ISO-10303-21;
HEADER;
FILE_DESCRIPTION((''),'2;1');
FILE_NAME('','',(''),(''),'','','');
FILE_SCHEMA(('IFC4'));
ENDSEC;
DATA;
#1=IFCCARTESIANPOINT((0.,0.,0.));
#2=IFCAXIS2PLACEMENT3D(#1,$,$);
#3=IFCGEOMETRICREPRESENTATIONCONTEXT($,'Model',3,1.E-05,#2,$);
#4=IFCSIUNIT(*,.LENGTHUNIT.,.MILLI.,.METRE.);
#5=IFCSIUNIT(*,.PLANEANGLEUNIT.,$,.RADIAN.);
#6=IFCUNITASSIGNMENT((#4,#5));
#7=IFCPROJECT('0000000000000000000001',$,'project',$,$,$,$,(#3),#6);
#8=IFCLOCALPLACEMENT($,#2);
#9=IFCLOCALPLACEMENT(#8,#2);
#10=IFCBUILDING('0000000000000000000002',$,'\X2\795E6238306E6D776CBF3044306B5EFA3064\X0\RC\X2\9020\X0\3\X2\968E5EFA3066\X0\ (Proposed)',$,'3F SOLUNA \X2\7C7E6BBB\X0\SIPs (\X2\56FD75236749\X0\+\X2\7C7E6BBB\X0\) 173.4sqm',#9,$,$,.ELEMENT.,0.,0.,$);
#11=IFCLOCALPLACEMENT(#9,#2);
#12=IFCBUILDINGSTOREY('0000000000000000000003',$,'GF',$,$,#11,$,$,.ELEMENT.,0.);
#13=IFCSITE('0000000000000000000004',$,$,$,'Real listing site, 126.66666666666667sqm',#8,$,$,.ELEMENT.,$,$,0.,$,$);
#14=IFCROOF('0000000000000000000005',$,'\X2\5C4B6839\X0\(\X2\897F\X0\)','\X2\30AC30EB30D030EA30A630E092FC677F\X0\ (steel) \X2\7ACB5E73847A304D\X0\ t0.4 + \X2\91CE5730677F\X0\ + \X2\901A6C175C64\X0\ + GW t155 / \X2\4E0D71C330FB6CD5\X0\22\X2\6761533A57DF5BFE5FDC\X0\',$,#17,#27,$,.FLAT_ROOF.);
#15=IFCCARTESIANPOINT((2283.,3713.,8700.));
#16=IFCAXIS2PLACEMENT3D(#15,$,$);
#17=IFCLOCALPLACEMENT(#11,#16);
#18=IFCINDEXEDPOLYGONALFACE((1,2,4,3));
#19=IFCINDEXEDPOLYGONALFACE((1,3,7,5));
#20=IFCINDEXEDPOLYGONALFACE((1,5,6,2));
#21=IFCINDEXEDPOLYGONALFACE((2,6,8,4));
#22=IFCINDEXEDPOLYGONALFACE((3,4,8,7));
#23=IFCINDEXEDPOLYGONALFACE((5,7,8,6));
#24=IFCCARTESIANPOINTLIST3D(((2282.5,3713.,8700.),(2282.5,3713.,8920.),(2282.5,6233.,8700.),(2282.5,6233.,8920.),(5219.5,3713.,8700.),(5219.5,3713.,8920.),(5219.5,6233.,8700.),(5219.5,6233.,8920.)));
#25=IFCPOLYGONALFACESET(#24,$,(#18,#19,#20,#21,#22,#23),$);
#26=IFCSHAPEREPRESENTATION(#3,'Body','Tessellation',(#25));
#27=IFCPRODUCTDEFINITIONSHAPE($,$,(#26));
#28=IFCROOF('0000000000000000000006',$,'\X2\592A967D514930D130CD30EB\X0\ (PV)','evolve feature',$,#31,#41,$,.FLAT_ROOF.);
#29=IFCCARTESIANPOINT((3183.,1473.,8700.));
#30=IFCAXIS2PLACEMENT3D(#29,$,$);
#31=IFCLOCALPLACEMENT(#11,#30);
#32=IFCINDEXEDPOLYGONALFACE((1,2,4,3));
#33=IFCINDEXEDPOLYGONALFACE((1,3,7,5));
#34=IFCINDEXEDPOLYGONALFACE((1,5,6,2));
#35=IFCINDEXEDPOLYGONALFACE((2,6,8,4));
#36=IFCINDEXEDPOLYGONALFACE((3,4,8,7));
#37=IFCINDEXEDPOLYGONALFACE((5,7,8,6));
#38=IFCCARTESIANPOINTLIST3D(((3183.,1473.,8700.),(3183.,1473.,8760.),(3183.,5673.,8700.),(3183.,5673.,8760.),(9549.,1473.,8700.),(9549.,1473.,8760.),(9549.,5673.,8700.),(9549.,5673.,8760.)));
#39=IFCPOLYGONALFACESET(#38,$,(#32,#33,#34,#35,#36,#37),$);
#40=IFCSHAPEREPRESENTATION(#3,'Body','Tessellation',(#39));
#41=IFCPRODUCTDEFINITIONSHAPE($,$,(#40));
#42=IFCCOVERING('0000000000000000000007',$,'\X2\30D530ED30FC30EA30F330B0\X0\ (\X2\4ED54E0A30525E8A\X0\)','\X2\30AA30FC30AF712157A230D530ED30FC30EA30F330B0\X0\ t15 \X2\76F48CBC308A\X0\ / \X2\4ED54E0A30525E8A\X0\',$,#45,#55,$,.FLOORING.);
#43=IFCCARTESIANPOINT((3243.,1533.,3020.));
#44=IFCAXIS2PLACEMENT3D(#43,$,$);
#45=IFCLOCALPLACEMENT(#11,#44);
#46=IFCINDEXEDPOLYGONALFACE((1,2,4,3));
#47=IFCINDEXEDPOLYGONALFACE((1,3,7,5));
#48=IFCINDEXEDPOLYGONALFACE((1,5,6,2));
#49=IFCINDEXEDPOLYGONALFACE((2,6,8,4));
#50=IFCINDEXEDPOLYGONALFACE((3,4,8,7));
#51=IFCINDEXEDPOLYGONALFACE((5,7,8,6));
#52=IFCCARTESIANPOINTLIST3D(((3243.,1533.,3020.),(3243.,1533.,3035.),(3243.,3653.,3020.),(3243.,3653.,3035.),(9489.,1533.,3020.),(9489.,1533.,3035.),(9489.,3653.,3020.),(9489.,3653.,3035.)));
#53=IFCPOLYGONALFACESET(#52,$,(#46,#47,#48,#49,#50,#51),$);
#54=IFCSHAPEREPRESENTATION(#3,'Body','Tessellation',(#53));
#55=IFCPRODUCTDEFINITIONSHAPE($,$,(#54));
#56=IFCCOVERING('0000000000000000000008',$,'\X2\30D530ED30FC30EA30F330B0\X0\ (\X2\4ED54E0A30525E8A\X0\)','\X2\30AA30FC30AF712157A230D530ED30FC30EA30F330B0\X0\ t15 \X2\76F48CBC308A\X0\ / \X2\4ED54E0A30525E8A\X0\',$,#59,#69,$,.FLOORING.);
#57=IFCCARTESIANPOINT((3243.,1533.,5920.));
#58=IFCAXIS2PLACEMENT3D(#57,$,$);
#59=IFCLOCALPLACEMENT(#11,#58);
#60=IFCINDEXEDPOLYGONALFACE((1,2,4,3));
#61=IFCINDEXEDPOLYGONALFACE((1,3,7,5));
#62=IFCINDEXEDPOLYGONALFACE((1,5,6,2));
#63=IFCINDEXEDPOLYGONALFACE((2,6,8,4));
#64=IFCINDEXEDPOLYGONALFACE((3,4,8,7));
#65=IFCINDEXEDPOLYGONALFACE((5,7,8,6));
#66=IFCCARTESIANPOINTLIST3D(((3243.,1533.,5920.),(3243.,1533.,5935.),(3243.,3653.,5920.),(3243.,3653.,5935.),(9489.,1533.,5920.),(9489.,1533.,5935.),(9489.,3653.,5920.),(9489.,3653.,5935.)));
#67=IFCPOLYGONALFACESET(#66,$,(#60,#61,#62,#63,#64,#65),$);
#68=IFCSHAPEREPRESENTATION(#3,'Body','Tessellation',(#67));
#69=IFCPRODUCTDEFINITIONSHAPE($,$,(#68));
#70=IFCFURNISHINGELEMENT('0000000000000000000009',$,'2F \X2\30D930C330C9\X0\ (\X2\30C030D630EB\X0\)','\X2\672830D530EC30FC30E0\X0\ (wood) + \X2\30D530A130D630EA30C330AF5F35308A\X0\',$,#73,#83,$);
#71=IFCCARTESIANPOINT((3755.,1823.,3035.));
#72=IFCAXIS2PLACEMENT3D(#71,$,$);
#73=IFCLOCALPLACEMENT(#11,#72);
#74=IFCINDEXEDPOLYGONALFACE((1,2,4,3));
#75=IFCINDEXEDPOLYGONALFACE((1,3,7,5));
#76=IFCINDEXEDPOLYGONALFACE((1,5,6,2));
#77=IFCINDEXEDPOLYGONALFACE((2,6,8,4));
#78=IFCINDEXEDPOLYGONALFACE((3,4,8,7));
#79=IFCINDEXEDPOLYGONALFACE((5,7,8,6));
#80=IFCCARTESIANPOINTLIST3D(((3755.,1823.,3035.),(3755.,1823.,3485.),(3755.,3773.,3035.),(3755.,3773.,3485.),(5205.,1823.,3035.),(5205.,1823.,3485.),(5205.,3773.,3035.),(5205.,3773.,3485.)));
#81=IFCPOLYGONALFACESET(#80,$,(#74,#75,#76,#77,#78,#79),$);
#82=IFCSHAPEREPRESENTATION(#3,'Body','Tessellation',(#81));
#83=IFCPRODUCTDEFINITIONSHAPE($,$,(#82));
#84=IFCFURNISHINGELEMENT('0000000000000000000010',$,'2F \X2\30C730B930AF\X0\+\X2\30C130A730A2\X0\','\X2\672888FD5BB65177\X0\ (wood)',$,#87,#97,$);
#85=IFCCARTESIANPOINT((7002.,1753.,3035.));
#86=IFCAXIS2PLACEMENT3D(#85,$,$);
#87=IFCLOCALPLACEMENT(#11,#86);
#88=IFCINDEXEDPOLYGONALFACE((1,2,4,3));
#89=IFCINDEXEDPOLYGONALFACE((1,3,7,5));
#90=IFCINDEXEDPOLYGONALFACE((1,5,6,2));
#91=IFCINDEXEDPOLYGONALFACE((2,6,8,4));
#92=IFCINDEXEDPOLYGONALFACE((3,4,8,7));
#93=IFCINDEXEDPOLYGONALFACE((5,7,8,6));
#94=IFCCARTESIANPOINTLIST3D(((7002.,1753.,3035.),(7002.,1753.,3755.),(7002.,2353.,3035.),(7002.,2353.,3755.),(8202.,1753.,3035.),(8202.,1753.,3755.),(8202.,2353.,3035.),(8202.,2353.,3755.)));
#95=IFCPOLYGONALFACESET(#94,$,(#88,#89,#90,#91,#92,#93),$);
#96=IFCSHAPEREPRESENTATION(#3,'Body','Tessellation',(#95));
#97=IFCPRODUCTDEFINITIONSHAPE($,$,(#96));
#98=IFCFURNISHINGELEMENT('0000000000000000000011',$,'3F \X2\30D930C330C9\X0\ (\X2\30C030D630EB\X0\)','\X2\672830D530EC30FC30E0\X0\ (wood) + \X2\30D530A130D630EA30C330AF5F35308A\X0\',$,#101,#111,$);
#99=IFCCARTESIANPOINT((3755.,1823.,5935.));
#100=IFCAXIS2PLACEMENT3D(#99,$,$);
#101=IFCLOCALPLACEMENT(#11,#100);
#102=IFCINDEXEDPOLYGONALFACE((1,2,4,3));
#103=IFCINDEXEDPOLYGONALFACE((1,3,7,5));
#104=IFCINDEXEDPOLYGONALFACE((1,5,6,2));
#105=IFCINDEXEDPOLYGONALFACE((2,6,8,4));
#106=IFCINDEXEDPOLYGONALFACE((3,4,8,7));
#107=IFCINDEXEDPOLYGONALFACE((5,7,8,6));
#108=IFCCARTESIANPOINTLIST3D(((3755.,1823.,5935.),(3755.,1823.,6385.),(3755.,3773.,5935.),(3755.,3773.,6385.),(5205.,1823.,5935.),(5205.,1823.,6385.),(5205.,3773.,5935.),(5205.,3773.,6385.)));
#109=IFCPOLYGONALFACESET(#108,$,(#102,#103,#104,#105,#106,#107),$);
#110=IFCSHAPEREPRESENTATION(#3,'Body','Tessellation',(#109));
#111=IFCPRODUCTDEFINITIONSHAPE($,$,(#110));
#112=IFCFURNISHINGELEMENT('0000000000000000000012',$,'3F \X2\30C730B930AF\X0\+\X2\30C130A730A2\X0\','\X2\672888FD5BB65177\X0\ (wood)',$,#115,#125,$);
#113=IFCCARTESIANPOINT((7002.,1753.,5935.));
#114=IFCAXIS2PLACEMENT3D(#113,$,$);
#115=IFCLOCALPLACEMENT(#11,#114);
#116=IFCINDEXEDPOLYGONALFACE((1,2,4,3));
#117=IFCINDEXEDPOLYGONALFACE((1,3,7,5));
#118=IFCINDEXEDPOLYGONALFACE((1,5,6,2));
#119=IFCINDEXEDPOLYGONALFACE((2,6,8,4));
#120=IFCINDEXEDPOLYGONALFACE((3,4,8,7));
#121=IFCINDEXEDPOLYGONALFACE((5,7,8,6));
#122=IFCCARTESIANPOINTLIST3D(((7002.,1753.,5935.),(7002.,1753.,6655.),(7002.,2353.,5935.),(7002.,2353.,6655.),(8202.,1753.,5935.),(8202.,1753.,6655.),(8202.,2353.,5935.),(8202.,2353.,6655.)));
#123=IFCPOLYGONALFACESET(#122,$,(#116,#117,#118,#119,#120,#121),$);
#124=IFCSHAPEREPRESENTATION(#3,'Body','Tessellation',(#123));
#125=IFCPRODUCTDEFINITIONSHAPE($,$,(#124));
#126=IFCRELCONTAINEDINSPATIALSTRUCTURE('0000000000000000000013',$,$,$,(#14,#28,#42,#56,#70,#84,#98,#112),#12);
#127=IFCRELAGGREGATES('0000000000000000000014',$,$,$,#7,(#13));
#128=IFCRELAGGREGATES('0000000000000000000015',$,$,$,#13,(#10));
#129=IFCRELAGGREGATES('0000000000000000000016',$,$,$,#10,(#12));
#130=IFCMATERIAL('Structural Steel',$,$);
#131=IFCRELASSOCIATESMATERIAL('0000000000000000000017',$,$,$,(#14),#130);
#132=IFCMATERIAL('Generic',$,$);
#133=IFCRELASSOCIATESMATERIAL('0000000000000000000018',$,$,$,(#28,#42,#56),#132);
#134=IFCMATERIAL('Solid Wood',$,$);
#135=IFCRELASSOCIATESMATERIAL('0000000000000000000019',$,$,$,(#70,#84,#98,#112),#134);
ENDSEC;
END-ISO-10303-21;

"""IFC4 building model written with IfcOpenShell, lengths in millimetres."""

from ifc_helpers import new_model, si_unit, frame, frame_2d, origin, place, context, project, spatial, rectangle, extrude, material, element, save


model = new_model("IFC4")

# Units and contexts
model_context = context("Model", 3, precision=1e-05, world=origin())
ifc_project = project(units=[si_unit("LENGTHUNIT", "METRE", prefix="MILLI"), si_unit("PLANEANGLEUNIT", "RADIAN")], contexts=[model_context])

# Site, building, storey
site_placement = place(None, origin())
site = spatial("IfcSite", under=ifc_project, at=site_placement, ObjectType="Real listing site, 126.66666666666667sqm", CompositionType="ELEMENT", RefElevation=0.0)
building_placement = place(site_placement, origin())
building = spatial("IfcBuilding", under=site, at=building_placement, Name="神戸の海沿いに建つRC造3階建て (Proposed)", ObjectType="3F SOLUNA 籾殻SIPs (国産杉+籾殻) 173.4sqm", CompositionType="ELEMENT", ElevationOfRefHeight=0.0, ElevationOfTerrain=0.0)
storey_placement = place(building_placement, origin())
storey = spatial("IfcBuildingStorey", under=building, at=storey_placement, Name="GF", CompositionType="ELEMENT", Elevation=0.0)

# Shared definitions
ifc_material_1 = material(Name="Solid Wood")

# Roofs
ifc_material_2 = material(Name="Structural Steel")
roof_1_placement = place(storey_placement, frame((2283.0, 3713.0, 8700.0)))
element("IfcRoof", 1, at=roof_1_placement, inside=storey, material=ifc_material_2, Name="屋根(西)", Description="ガルバリウム鋼板 (steel) 立平葺き t0.4 + 野地板 + 通気層 + GW t155 / 不燃・法22条区域対応", PredefinedType="FLAT_ROOF", context=model_context, shape_type="SweptSolid", body=[
    extrude(rectangle(XDim=2937.0, YDim=2520.0, at=frame_2d((1468.0, 1260.0))), frame((2283.0, 3713.0, 8700.0)), (0.0, 0.0, 1.0), 220.0),
])
ifc_material_3 = material(Name="Generic")
roof_2_placement = place(storey_placement, frame((3183.0, 1473.0, 8700.0)))
element("IfcRoof", 2, at=roof_2_placement, inside=storey, material=ifc_material_3, Name="太陽光パネル (PV)", Description="evolve feature", PredefinedType="FLAT_ROOF", context=model_context, shape_type="SweptSolid", body=[
    extrude(rectangle(XDim=6366.0, YDim=4200.0, at=frame_2d((3183.0, 2100.0))), frame((3183.0, 1473.0, 8700.0)), (0.0, 0.0, 1.0), 60.0),
])

# Coverings
covering_1_placement = place(storey_placement, frame((3243.0, 1533.0, 3020.0)))
element("IfcCovering", 3, at=covering_1_placement, inside=storey, material=ifc_material_3, Name="フローリング (仕上げ床)", Description="オーク無垢フローリング t15 直貼り / 仕上げ床", PredefinedType="FLOORING", context=model_context, shape_type="SweptSolid", body=[
    extrude(rectangle(XDim=6246.0, YDim=2120.0, at=frame_2d((3123.0, 1060.0))), frame((3243.0, 1533.0, 3020.0)), (0.0, 0.0, 1.0), 15.0),
])
covering_2_placement = place(storey_placement, frame((3243.0, 1533.0, 5920.0)))
element("IfcCovering", 4, at=covering_2_placement, inside=storey, material=ifc_material_3, Name="フローリング (仕上げ床)", Description="オーク無垢フローリング t15 直貼り / 仕上げ床", PredefinedType="FLOORING", context=model_context, shape_type="SweptSolid", body=[
    extrude(rectangle(XDim=6246.0, YDim=2120.0, at=frame_2d((3123.0, 1060.0))), frame((3243.0, 1533.0, 5920.0)), (0.0, 0.0, 1.0), 15.0),
])

# Furnishing elements
furnishing_1_placement = place(storey_placement, frame((3755.0, 1823.0, 3035.0)))
element("IfcFurnishingElement", 5, at=furnishing_1_placement, inside=storey, material=ifc_material_1, Name="2F ベッド (ダブル)", Description="木フレーム (wood) + ファブリック張り", context=model_context, shape_type="SweptSolid", body=[
    extrude(rectangle(XDim=1450.0, YDim=1950.0, at=frame_2d((725.0, 975.0))), frame((3755.0, 1823.0, 3035.0)), (0.0, 0.0, 1.0), 450.0),
])
furnishing_2_placement = place(storey_placement, frame((7002.0, 1753.0, 3035.0)))
element("IfcFurnishingElement", 6, at=furnishing_2_placement, inside=storey, material=ifc_material_1, Name="2F デスク+チェア", Description="木製家具 (wood)", context=model_context, shape_type="SweptSolid", body=[
    extrude(rectangle(XDim=1200.0, YDim=600.0, at=frame_2d((600.0, 300.0))), frame((7002.0, 1753.0, 3035.0)), (0.0, 0.0, 1.0), 720.0),
])
furnishing_3_placement = place(storey_placement, frame((3755.0, 1823.0, 5935.0)))
element("IfcFurnishingElement", 7, at=furnishing_3_placement, inside=storey, material=ifc_material_1, Name="3F ベッド (ダブル)", Description="木フレーム (wood) + ファブリック張り", context=model_context, shape_type="SweptSolid", body=[
    extrude(rectangle(XDim=1450.0, YDim=1950.0, at=frame_2d((725.0, 975.0))), frame((3755.0, 1823.0, 5935.0)), (0.0, 0.0, 1.0), 450.0),
])
furnishing_4_placement = place(storey_placement, frame((7002.0, 1753.0, 5935.0)))
element("IfcFurnishingElement", 8, at=furnishing_4_placement, inside=storey, material=ifc_material_1, Name="3F デスク+チェア", Description="木製家具 (wood)", context=model_context, shape_type="SweptSolid", body=[
    extrude(rectangle(XDim=1200.0, YDim=600.0, at=frame_2d((600.0, 300.0))), frame((7002.0, 1753.0, 5935.0)), (0.0, 0.0, 1.0), 720.0),
])

save(model, "model.ifc")
